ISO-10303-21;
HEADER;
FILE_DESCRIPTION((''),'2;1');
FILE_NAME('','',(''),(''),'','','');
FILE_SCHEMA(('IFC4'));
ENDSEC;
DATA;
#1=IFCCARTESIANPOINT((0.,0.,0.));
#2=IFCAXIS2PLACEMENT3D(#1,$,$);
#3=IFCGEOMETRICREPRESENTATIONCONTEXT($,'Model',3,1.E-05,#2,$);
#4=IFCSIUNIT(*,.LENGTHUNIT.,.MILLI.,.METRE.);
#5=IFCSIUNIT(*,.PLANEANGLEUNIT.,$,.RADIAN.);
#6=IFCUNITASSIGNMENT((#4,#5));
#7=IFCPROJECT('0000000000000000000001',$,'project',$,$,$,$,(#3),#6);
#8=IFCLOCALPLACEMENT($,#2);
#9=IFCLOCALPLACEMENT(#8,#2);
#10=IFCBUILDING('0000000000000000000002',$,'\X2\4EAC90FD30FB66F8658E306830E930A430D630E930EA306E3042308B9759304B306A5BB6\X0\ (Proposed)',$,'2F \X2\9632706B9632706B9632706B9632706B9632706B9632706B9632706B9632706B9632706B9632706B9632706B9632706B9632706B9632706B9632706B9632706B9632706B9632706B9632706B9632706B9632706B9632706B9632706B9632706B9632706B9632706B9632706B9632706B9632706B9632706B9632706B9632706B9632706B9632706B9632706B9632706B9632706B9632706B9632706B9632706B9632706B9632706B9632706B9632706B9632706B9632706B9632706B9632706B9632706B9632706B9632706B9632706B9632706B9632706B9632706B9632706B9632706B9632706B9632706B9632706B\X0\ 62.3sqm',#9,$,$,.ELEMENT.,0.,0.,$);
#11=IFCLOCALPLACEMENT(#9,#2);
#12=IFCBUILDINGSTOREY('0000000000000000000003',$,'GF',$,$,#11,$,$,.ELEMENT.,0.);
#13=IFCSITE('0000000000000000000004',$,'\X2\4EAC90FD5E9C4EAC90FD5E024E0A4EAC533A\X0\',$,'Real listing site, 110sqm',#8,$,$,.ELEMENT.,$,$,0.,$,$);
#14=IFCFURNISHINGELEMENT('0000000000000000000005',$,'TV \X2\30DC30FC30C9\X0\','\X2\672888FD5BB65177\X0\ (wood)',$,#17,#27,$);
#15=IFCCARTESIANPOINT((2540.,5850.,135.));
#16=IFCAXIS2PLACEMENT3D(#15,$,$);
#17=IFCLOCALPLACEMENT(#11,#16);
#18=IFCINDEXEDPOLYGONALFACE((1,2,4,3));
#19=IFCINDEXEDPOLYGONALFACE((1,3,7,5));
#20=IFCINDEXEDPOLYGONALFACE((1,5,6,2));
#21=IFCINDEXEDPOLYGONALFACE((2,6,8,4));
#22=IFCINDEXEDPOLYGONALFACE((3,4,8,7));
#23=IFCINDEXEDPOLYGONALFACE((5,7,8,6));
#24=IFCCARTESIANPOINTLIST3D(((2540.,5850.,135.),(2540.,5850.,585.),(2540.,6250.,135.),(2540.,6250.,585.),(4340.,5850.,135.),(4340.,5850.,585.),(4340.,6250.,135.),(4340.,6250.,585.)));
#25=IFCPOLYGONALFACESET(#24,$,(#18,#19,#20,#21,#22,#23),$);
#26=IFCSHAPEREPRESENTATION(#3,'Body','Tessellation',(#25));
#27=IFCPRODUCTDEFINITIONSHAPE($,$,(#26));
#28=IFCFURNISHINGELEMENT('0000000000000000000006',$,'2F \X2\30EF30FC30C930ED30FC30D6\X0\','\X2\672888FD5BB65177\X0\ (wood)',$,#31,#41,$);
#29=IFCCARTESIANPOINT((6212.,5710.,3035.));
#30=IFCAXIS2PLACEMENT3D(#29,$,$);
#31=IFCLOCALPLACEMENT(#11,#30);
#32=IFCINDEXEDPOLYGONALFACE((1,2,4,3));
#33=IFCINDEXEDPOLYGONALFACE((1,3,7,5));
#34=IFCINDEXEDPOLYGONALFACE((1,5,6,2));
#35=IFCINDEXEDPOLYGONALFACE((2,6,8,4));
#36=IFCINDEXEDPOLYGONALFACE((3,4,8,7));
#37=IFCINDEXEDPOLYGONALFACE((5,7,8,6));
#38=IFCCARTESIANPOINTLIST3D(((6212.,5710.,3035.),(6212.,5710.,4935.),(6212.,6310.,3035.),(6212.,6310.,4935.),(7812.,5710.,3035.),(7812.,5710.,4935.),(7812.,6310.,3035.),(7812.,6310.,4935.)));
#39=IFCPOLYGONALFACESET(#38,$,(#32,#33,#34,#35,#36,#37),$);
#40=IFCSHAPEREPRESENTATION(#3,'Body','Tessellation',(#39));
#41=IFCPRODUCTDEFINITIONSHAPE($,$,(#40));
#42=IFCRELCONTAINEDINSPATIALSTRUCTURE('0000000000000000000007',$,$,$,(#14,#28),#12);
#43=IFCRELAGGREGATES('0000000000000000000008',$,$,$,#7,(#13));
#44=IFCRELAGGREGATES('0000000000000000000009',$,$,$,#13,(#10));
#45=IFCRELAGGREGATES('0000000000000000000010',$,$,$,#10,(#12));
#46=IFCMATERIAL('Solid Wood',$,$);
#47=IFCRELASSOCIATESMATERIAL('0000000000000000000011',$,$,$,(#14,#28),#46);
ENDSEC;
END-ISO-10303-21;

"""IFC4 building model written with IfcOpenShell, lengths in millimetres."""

from ifc_helpers import new_model, si_unit, frame, frame_2d, origin, place, context, project, spatial, rectangle, extrude, material, element, save


model = new_model("IFC4")

# Units and contexts
model_context = context("Model", 3, precision=1e-05, world=origin())
ifc_project = project(units=[si_unit("LENGTHUNIT", "METRE", prefix="MILLI"), si_unit("PLANEANGLEUNIT", "RADIAN")], contexts=[model_context])

# Site, building, storey
site_placement = place(None, origin())
site = spatial("IfcSite", under=ifc_project, at=site_placement, Name="京都府京都市上京区", ObjectType="Real listing site, 110sqm", CompositionType="ELEMENT", RefElevation=0.0)
building_placement = place(site_placement, origin())
building = spatial("IfcBuilding", under=site, at=building_placement, Name="京都・書斎とライブラリのある静かな家 (Proposed)", ObjectType="2F 防火防火防火防火防火防火防火防火防火防火防火防火防火防火防火防火防火防火防火防火防火防火防火防火防火防火防火防火防火防火防火防火防火防火防火防火防火防火防火防火防火防火防火防火防火防火防火防火防火防火防火防火防火防火防火防火防火防火防火防火 62.3sqm", CompositionType="ELEMENT", ElevationOfRefHeight=0.0, ElevationOfTerrain=0.0)
storey_placement = place(building_placement, origin())
storey = spatial("IfcBuildingStorey", under=building, at=storey_placement, Name="GF", CompositionType="ELEMENT", Elevation=0.0)

# Shared definitions
ifc_material_1 = material(Name="Solid Wood")

# Furnishing elements
furnishing_1_placement = place(storey_placement, frame((2540.0, 5850.0, 135.0)))
element("IfcFurnishingElement", 1, at=furnishing_1_placement, inside=storey, material=ifc_material_1, Name="TV ボード", Description="木製家具 (wood)", context=model_context, shape_type="SweptSolid", body=[
    extrude(rectangle(XDim=1800.0, YDim=400.0, at=frame_2d((900.0, 200.0))), frame((2540.0, 5850.0, 135.0)), (0.0, 0.0, 1.0), 450.0),
])
furnishing_2_placement = place(storey_placement, frame((6212.0, 5710.0, 3035.0)))
element("IfcFurnishingElement", 2, at=furnishing_2_placement, inside=storey, material=ifc_material_1, Name="2F ワードローブ", Description="木製家具 (wood)", context=model_context, shape_type="SweptSolid", body=[
    extrude(rectangle(XDim=1600.0, YDim=600.0, at=frame_2d((800.0, 300.0))), frame((6212.0, 5710.0, 3035.0)), (0.0, 0.0, 1.0), 1900.0),
])

save(model, "model.ifc")
